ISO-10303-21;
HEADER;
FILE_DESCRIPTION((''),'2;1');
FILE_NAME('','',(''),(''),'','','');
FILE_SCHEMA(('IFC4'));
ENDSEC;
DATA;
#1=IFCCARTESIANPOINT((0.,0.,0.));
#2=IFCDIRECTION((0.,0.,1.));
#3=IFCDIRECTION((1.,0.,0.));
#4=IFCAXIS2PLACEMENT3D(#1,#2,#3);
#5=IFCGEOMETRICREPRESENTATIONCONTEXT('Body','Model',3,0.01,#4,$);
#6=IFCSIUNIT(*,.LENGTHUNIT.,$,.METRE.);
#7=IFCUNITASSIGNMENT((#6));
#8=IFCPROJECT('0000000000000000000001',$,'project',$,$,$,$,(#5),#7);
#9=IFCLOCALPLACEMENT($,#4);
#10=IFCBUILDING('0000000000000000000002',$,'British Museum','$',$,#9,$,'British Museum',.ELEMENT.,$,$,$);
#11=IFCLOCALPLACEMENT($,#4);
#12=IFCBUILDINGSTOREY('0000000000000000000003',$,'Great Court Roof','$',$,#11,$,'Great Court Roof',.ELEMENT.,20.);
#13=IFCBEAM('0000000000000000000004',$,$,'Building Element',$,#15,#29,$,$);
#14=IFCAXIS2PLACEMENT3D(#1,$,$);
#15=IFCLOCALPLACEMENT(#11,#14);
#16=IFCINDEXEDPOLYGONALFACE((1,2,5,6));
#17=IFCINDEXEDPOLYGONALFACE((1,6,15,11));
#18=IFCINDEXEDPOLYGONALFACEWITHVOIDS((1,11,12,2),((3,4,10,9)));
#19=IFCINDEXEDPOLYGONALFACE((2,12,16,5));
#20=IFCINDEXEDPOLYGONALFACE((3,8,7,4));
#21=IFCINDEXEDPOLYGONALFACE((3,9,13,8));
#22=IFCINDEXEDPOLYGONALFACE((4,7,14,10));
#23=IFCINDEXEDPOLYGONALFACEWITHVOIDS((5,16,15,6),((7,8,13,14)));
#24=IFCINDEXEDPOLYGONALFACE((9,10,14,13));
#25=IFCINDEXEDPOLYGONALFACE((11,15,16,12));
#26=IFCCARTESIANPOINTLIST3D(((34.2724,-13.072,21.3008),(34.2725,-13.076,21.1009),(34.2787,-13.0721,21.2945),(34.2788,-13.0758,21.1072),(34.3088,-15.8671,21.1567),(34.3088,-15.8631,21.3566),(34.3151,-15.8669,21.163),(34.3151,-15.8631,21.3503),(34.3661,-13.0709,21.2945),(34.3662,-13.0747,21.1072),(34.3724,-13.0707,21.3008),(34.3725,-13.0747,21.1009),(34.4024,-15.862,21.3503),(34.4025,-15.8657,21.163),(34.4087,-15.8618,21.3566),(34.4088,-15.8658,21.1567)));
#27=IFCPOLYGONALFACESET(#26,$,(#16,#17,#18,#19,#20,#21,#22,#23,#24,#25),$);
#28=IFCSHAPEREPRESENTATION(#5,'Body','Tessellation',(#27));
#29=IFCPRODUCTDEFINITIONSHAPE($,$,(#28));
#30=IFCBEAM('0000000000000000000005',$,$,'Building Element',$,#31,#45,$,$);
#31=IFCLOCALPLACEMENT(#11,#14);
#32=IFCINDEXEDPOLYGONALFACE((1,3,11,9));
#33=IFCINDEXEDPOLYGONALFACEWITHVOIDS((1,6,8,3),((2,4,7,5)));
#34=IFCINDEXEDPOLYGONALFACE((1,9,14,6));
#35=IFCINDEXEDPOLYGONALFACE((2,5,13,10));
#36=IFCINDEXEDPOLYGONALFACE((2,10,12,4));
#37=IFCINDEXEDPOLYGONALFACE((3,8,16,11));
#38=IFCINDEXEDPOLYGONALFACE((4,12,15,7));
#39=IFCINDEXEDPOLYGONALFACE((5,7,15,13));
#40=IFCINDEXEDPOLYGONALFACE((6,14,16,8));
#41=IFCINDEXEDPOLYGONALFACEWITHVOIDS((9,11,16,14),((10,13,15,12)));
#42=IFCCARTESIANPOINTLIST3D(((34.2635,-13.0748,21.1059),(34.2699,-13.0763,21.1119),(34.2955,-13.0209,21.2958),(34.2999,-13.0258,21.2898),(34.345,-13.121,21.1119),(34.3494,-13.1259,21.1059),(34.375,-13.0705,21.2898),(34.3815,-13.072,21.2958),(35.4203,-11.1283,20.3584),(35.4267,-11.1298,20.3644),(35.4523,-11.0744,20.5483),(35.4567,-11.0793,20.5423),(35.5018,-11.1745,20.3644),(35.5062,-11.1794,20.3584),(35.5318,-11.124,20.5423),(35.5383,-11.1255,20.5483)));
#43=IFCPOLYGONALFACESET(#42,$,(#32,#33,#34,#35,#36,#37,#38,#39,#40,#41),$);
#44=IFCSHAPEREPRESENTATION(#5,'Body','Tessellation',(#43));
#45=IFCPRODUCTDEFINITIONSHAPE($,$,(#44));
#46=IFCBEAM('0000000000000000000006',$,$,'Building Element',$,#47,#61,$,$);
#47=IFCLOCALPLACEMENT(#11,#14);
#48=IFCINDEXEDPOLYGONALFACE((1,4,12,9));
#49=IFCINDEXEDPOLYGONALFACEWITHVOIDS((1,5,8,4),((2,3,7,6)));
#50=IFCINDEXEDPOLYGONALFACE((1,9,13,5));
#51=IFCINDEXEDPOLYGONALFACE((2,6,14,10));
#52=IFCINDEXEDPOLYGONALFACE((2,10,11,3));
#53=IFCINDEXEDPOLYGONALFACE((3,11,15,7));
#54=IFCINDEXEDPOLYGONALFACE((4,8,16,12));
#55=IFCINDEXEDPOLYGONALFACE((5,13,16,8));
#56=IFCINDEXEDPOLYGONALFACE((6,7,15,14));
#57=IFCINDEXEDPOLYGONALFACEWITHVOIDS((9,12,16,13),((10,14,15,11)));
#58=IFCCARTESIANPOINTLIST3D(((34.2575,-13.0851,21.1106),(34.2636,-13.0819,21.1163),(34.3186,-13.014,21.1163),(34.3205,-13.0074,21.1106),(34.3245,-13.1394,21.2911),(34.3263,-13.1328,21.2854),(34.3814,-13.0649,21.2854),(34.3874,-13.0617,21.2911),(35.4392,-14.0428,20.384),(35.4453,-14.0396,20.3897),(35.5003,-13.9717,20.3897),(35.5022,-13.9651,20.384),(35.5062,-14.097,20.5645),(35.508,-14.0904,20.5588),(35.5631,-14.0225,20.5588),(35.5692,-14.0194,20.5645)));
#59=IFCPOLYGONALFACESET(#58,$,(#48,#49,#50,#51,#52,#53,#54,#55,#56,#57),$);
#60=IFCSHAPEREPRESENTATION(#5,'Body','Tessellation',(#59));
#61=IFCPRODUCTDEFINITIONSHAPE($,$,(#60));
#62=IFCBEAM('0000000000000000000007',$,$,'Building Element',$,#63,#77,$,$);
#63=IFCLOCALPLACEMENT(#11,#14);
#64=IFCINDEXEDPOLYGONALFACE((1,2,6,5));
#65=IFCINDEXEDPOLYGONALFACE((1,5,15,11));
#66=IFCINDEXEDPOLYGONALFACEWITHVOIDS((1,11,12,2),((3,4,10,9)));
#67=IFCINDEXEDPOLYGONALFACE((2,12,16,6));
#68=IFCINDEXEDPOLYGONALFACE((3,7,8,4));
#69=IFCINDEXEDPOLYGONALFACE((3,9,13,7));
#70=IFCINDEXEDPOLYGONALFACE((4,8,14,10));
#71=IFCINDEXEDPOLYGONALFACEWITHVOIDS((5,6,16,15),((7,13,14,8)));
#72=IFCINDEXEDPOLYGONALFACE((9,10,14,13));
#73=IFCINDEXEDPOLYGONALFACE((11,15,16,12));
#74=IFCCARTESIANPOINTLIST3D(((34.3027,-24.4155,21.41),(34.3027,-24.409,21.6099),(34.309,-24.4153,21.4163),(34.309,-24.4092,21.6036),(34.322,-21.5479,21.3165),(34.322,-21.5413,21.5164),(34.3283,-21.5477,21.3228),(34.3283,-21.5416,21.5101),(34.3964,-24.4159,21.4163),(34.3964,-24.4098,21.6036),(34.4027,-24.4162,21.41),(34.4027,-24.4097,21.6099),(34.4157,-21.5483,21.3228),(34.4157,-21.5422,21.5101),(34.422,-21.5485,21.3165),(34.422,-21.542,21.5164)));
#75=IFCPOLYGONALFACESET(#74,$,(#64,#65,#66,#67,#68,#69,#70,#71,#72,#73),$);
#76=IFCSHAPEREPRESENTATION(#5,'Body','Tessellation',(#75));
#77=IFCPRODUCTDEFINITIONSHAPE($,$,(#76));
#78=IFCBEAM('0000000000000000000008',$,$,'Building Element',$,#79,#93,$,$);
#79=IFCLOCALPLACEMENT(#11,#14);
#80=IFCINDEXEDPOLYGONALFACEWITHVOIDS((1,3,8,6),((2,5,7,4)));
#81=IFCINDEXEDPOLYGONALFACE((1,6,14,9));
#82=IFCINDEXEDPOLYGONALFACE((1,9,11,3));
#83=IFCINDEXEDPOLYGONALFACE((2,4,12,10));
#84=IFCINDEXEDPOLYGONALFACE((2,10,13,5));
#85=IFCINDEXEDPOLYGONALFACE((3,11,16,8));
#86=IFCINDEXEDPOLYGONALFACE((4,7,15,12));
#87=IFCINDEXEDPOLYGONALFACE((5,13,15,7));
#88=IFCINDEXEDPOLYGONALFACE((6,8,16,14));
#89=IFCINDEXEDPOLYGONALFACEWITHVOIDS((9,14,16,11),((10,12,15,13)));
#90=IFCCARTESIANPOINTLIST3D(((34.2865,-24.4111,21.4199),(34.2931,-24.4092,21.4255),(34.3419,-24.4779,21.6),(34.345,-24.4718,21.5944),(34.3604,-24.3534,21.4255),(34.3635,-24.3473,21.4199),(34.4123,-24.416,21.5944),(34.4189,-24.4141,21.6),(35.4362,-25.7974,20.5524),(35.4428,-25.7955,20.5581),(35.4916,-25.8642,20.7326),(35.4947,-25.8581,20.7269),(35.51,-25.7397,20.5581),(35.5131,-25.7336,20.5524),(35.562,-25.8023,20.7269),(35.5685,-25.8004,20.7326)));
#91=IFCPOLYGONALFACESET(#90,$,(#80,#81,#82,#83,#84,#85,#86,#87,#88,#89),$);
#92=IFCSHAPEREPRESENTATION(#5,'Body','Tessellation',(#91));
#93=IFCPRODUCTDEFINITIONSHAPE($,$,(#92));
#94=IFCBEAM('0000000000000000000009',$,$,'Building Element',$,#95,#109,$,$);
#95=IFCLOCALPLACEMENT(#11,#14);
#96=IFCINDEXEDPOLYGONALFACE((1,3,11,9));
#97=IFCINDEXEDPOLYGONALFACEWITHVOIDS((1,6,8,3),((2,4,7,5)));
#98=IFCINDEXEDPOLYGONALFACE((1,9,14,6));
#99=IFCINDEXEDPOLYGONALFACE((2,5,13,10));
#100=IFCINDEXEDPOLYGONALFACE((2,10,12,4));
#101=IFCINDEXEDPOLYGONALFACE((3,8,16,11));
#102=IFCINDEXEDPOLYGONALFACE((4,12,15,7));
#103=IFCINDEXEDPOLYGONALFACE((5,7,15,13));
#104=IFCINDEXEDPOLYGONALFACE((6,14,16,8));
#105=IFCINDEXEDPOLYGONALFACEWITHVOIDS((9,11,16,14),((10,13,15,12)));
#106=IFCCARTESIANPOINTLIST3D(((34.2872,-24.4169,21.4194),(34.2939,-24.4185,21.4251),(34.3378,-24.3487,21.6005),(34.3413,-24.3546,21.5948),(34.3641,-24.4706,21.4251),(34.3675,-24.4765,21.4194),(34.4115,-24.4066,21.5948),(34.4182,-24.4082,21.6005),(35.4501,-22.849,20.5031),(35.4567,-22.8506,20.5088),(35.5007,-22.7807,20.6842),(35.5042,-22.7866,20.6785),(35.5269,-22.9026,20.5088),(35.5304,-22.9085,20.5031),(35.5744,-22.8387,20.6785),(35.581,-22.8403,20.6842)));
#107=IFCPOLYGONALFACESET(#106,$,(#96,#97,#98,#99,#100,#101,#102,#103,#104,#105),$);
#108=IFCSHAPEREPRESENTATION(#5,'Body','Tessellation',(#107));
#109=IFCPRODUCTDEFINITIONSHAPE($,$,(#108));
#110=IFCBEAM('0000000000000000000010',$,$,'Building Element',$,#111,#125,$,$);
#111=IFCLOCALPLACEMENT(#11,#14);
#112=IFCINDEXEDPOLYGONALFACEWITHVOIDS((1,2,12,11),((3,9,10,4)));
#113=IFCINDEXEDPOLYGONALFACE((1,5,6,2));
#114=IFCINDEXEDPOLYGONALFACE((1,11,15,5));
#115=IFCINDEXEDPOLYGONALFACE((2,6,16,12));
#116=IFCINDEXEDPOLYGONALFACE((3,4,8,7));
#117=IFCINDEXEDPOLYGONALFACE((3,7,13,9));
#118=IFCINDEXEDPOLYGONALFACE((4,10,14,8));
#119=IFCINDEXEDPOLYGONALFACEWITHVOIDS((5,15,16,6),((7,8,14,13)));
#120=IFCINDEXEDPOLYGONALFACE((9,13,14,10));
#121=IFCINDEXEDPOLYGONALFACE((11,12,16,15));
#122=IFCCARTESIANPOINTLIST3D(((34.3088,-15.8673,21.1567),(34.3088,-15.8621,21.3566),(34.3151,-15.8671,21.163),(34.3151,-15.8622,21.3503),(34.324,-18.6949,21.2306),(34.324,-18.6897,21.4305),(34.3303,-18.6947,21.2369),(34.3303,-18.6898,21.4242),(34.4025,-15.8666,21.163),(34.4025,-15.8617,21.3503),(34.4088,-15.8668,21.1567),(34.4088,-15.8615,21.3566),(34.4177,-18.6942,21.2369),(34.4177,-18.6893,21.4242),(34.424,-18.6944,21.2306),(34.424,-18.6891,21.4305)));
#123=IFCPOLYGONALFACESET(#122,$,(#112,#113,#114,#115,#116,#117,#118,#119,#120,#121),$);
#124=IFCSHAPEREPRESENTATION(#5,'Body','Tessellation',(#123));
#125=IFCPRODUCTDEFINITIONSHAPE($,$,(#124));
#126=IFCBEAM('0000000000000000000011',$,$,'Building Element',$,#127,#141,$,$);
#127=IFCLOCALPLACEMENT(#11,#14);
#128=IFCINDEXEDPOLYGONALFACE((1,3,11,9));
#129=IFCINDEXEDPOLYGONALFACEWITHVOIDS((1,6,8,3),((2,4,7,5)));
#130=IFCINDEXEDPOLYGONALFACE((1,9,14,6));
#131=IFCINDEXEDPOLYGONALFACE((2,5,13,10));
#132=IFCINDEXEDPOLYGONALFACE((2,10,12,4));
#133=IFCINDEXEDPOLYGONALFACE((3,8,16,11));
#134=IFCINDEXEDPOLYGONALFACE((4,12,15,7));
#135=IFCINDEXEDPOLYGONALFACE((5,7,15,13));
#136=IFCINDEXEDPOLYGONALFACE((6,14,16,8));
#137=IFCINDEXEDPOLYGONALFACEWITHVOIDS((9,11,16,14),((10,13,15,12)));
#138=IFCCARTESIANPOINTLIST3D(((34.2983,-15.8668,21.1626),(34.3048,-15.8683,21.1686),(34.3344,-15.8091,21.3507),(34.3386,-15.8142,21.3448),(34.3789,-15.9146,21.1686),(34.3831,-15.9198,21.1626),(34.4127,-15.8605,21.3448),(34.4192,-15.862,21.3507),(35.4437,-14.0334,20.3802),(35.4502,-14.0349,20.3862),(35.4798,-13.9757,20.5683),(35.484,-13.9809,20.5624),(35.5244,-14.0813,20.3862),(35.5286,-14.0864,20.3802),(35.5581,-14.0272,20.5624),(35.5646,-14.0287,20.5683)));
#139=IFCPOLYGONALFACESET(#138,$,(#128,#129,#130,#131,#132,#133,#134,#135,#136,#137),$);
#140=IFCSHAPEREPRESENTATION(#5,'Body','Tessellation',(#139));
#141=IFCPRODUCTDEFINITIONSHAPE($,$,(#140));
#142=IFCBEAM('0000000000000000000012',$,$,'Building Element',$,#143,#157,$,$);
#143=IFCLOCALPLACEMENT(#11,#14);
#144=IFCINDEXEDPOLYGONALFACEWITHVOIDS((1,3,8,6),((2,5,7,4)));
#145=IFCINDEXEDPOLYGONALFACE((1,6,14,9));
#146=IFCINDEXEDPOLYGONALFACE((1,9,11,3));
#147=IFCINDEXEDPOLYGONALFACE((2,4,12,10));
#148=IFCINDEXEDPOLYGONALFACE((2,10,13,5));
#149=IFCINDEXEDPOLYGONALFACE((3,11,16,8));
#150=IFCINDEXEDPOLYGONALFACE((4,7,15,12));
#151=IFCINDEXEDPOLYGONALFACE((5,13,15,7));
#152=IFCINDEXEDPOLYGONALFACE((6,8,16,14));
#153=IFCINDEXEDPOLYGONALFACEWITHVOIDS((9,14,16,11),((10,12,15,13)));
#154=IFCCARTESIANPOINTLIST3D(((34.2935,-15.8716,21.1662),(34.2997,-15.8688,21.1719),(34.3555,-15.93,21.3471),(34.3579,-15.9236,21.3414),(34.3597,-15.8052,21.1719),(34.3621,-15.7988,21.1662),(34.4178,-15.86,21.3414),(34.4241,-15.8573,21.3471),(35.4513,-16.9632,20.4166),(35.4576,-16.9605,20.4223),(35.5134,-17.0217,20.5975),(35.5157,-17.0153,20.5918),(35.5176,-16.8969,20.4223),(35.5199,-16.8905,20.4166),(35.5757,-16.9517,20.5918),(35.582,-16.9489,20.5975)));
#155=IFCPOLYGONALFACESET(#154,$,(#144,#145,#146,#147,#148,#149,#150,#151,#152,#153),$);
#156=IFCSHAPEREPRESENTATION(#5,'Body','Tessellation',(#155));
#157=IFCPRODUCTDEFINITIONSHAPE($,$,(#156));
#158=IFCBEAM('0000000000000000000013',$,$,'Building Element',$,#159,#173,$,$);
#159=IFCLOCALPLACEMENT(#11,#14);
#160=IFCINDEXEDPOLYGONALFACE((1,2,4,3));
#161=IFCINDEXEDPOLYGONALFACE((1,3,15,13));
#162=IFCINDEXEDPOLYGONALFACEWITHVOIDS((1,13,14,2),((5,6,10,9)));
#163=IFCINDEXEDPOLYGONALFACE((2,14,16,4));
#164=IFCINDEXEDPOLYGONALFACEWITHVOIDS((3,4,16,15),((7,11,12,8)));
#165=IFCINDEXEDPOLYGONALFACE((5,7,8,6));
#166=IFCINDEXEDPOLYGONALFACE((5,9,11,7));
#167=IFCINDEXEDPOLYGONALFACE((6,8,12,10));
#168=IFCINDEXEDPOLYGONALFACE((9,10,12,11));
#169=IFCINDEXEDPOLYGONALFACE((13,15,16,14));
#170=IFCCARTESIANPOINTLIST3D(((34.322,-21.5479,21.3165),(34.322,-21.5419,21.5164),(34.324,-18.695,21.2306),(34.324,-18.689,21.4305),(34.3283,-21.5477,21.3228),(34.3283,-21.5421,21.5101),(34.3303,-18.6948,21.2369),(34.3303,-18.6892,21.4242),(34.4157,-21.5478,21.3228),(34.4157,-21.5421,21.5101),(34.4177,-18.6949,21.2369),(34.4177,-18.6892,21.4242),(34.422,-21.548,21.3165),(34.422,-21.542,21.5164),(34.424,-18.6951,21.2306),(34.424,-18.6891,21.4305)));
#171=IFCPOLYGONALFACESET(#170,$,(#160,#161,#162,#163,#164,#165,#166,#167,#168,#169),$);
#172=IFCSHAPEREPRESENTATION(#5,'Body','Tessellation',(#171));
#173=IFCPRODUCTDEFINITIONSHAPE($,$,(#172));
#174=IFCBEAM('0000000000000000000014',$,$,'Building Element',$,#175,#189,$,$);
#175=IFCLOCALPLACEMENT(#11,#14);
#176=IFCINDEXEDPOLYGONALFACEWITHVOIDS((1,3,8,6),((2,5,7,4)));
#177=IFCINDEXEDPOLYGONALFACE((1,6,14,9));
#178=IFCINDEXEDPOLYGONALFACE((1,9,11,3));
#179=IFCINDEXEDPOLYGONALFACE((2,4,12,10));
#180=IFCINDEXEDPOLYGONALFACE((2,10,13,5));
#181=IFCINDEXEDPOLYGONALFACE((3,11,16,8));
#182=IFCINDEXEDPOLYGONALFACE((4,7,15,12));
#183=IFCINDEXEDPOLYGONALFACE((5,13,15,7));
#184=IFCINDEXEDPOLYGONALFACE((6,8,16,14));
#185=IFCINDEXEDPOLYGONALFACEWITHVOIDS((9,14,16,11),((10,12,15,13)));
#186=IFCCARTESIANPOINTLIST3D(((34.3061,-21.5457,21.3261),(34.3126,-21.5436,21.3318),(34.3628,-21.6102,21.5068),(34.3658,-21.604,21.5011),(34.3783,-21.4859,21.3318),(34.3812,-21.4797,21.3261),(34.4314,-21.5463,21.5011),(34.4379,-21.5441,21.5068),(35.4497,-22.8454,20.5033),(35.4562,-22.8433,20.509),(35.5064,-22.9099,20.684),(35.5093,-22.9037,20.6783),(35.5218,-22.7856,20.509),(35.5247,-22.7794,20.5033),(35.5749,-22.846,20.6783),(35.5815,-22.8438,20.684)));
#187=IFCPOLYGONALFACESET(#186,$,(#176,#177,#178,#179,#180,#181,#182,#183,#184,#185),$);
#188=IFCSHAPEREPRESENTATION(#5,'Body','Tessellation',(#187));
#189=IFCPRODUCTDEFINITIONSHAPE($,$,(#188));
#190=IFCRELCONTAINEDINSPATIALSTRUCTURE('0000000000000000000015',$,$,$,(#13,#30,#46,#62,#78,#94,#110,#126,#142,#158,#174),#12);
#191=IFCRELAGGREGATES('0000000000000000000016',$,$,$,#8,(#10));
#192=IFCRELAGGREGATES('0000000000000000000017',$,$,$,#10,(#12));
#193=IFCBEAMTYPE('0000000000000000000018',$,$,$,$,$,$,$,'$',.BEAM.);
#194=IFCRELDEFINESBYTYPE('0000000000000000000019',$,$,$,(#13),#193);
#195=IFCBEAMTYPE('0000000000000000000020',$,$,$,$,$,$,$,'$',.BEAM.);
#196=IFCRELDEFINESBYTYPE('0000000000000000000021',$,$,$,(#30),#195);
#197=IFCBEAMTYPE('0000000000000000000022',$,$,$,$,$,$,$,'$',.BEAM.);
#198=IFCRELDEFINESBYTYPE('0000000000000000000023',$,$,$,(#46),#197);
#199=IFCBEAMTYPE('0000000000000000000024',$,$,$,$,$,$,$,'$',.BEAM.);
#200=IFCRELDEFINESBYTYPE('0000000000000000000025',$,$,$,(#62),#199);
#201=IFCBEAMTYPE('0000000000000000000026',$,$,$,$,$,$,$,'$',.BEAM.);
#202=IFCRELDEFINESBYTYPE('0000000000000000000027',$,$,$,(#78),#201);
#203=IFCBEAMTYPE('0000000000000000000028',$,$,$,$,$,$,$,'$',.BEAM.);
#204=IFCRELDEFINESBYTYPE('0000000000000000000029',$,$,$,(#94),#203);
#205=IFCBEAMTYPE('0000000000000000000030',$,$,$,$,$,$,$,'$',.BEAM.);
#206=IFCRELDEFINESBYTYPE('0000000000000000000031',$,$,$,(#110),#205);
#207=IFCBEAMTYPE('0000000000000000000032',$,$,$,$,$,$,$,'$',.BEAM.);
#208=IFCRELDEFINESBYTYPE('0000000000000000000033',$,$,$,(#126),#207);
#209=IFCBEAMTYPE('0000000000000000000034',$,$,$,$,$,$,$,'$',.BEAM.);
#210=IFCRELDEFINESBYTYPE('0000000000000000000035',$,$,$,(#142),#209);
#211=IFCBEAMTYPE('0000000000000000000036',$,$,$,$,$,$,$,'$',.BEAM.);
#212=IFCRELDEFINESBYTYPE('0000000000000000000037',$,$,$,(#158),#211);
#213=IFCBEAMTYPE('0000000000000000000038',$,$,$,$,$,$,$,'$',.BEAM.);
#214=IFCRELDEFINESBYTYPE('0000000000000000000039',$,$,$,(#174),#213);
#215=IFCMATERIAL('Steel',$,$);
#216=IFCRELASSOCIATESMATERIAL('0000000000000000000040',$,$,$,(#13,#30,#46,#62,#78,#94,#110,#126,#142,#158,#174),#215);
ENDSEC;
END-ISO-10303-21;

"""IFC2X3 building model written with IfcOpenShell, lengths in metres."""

from ifc_helpers import new_model, si_unit, frame, origin_with_axes, origin_2d, place, context, project, spatial, hollow_rectangle, extrude, material, type_object, element, save


model = new_model("IFC2X3")

# Units and contexts
model_context = context("Model", 3, precision=0.01, world=origin_with_axes(), identifier="Body")
ifc_project = project(units=[si_unit("LENGTHUNIT", "METRE")], contexts=[model_context])

# Building, storey
building_placement = place(None, origin_with_axes())
building = spatial("IfcBuilding", under=ifc_project, at=building_placement, Name="British Museum", Description="$", LongName="British Museum", CompositionType="ELEMENT")
storey_placement = place(None, origin_with_axes())
storey = spatial("IfcBuildingStorey", under=building, at=storey_placement, Name="Great Court Roof", Description="$", LongName="Great Court Roof", CompositionType="ELEMENT", Elevation=20.0)

# Beams
ifc_material = material(Name="Steel")
beam_type_1 = type_object("IfcBeamType", ElementType="$", PredefinedType="BEAM")
beam_1_placement = place(None, origin_with_axes())
element("IfcBeam", 1, at=beam_1_placement, inside=storey, type_object=beam_type_1, material=ifc_material, Description="Building Element", context=model_context, shape_type="SweptSolid", body=[
    extrude(hollow_rectangle(XDim=0.1, YDim=0.2, WallThickness=0.0063, InnerFilletRadius=0.0, OuterFilletRadius=0.0, at=origin_2d()), frame((34.3225, -13.0734, 21.2008), z_axis=(0.013007, -0.999715, 0.019998), x_axis=(0.999915, 0.013009, 0.0)), (0.0, 0.0, 1.0), 2.7918),
])
beam_type_2 = type_object("IfcBeamType", ElementType="$", PredefinedType="BEAM")
beam_2_placement = place(None, origin_with_axes())
element("IfcBeam", 2, at=beam_2_placement, inside=storey, type_object=beam_type_2, material=ifc_material, Description="Building Element", context=model_context, shape_type="SweptSolid", body=[
    extrude(hollow_rectangle(XDim=0.1, YDim=0.2, WallThickness=0.0063, InnerFilletRadius=0.0, OuterFilletRadius=0.0, at=origin_2d()), frame((34.3225, -13.0734, 21.2008), z_axis=(0.485142, 0.816313, -0.313481), x_axis=(-0.859644, 0.510894, 0.0)), (0.0, 0.0, 1.0), 2.3845),
])
beam_type_3 = type_object("IfcBeamType", ElementType="$", PredefinedType="BEAM")
beam_3_placement = place(None, origin_with_axes())
element("IfcBeam", 3, at=beam_3_placement, inside=storey, type_object=beam_type_3, material=ifc_material, Description="Building Element", context=model_context, shape_type="SweptSolid", body=[
    extrude(hollow_rectangle(XDim=0.1, YDim=0.2, WallThickness=0.0063, InnerFilletRadius=0.0, OuterFilletRadius=0.0, at=origin_2d()), frame((34.3225, -13.0734, 21.2008), z_axis=(0.701037, -0.568124, -0.431025), x_axis=(0.629612, 0.77691, 0.0)), (0.0, 0.0, 1.0), 1.6857),
])
beam_type_4 = type_object("IfcBeamType", ElementType="$", PredefinedType="BEAM")
beam_4_placement = place(None, origin_with_axes())
element("IfcBeam", 4, at=beam_4_placement, inside=storey, type_object=beam_type_4, material=ifc_material, Description="Building Element", context=model_context, shape_type="SweptSolid", body=[
    extrude(hollow_rectangle(XDim=0.1, YDim=0.2, WallThickness=0.0063, InnerFilletRadius=0.0, OuterFilletRadius=0.0, at=origin_2d()), frame((34.3527, -24.4126, 21.5099), z_axis=(0.006738, 0.999446, -0.032587), x_axis=(-0.999977, 0.006742, 0.0)), (0.0, 0.0, 1.0), 2.8692),
])
beam_type_5 = type_object("IfcBeamType", ElementType="$", PredefinedType="BEAM")
beam_5_placement = place(None, origin_with_axes())
element("IfcBeam", 5, at=beam_5_placement, inside=storey, type_object=beam_type_5, material=ifc_material, Description="Building Element", context=model_context, shape_type="SweptSolid", body=[
    extrude(hollow_rectangle(XDim=0.1, YDim=0.2, WallThickness=0.0063, InnerFilletRadius=0.0, OuterFilletRadius=0.0, at=origin_2d()), frame((34.3527, -24.4126, 21.5099), z_axis=(0.57512, -0.693506, -0.433921), x_axis=(0.769748, 0.638347, 0.0)), (0.0, 0.0, 1.0), 1.999),
])
beam_type_6 = type_object("IfcBeamType", ElementType="$", PredefinedType="BEAM")
beam_6_placement = place(None, origin_with_axes())
element("IfcBeam", 6, at=beam_6_placement, inside=storey, type_object=beam_type_6, material=ifc_material, Description="Building Element", context=model_context, shape_type="SweptSolid", body=[
    extrude(hollow_rectangle(XDim=0.1, YDim=0.2, WallThickness=0.0063, InnerFilletRadius=0.0, OuterFilletRadius=0.0, at=origin_2d()), frame((34.3527, -24.4126, 21.5099), z_axis=(0.539247, 0.727094, -0.424909), x_axis=(-0.803209, 0.595697, 0.0)), (0.0, 0.0, 1.0), 2.1565),
])
beam_type_7 = type_object("IfcBeamType", ElementType="$", PredefinedType="BEAM")
beam_7_placement = place(None, origin_with_axes())
element("IfcBeam", 7, at=beam_7_placement, inside=storey, type_object=beam_type_7, material=ifc_material, Description="Building Element", context=model_context, shape_type="SweptSolid", body=[
    extrude(hollow_rectangle(XDim=0.1, YDim=0.2, WallThickness=0.0063, InnerFilletRadius=0.0, OuterFilletRadius=0.0, at=origin_2d()), frame((34.3588, -15.8644, 21.2567), z_axis=(0.005392, -0.999644, 0.026112), x_axis=(0.999985, 0.005394, 0.0)), (0.0, 0.0, 1.0), 2.8286),
])
beam_type_8 = type_object("IfcBeamType", ElementType="$", PredefinedType="BEAM")
beam_8_placement = place(None, origin_with_axes())
element("IfcBeam", 8, at=beam_8_placement, inside=storey, type_object=beam_type_8, material=ifc_material, Description="Building Element", context=model_context, shape_type="SweptSolid", body=[
    extrude(hollow_rectangle(XDim=0.1, YDim=0.2, WallThickness=0.0063, InnerFilletRadius=0.0, OuterFilletRadius=0.0, at=origin_2d()), frame((34.3588, -15.8644, 21.2567), z_axis=(0.498225, 0.797466, -0.340324), x_axis=(-0.84809, 0.529852, 0.0)), (0.0, 0.0, 1.0), 2.299),
])
beam_type_9 = type_object("IfcBeamType", ElementType="$", PredefinedType="BEAM")
beam_9_placement = place(None, origin_with_axes())
element("IfcBeam", 9, at=beam_9_placement, inside=storey, type_object=beam_type_9, material=ifc_material, Description="Building Element", context=model_context, shape_type="SweptSolid", body=[
    extrude(hollow_rectangle(XDim=0.1, YDim=0.2, WallThickness=0.0063, InnerFilletRadius=0.0, OuterFilletRadius=0.0, at=origin_2d()), frame((34.3588, -15.8644, 21.2567), z_axis=(0.658228, -0.62059, -0.42615), x_axis=(0.685999, 0.727603, 0.0)), (0.0, 0.0, 1.0), 1.7591),
])
beam_type_10 = type_object("IfcBeamType", ElementType="$", PredefinedType="BEAM")
beam_10_placement = place(None, origin_with_axes())
element("IfcBeam", 10, at=beam_10_placement, inside=storey, type_object=beam_type_10, material=ifc_material, Description="Building Element", context=model_context, shape_type="SweptSolid", body=[
    extrude(hollow_rectangle(XDim=0.1, YDim=0.2, WallThickness=0.0063, InnerFilletRadius=0.0, OuterFilletRadius=0.0, at=origin_2d()), frame((34.372, -21.5449, 21.4164), z_axis=(0.000704, 0.999547, -0.030104), x_axis=(-1.0, 0.000705, 0.0)), (0.0, 0.0, 1.0), 2.8542),
])
beam_type_11 = type_object("IfcBeamType", ElementType="$", PredefinedType="BEAM")
beam_11_placement = place(None, origin_with_axes())
element("IfcBeam", 11, at=beam_11_placement, inside=storey, type_object=beam_type_11, material=ifc_material, Description="Building Element", context=model_context, shape_type="SweptSolid", body=[
    extrude(hollow_rectangle(XDim=0.1, YDim=0.2, WallThickness=0.0063, InnerFilletRadius=0.0, OuterFilletRadius=0.0, at=origin_2d()), frame((34.372, -21.5449, 21.4164), z_axis=(0.596607, -0.678073, -0.429274), x_axis=(0.750767, 0.660567, 0.0)), (0.0, 0.0, 1.0), 1.9167),
])

save(model, "model.ifc")
